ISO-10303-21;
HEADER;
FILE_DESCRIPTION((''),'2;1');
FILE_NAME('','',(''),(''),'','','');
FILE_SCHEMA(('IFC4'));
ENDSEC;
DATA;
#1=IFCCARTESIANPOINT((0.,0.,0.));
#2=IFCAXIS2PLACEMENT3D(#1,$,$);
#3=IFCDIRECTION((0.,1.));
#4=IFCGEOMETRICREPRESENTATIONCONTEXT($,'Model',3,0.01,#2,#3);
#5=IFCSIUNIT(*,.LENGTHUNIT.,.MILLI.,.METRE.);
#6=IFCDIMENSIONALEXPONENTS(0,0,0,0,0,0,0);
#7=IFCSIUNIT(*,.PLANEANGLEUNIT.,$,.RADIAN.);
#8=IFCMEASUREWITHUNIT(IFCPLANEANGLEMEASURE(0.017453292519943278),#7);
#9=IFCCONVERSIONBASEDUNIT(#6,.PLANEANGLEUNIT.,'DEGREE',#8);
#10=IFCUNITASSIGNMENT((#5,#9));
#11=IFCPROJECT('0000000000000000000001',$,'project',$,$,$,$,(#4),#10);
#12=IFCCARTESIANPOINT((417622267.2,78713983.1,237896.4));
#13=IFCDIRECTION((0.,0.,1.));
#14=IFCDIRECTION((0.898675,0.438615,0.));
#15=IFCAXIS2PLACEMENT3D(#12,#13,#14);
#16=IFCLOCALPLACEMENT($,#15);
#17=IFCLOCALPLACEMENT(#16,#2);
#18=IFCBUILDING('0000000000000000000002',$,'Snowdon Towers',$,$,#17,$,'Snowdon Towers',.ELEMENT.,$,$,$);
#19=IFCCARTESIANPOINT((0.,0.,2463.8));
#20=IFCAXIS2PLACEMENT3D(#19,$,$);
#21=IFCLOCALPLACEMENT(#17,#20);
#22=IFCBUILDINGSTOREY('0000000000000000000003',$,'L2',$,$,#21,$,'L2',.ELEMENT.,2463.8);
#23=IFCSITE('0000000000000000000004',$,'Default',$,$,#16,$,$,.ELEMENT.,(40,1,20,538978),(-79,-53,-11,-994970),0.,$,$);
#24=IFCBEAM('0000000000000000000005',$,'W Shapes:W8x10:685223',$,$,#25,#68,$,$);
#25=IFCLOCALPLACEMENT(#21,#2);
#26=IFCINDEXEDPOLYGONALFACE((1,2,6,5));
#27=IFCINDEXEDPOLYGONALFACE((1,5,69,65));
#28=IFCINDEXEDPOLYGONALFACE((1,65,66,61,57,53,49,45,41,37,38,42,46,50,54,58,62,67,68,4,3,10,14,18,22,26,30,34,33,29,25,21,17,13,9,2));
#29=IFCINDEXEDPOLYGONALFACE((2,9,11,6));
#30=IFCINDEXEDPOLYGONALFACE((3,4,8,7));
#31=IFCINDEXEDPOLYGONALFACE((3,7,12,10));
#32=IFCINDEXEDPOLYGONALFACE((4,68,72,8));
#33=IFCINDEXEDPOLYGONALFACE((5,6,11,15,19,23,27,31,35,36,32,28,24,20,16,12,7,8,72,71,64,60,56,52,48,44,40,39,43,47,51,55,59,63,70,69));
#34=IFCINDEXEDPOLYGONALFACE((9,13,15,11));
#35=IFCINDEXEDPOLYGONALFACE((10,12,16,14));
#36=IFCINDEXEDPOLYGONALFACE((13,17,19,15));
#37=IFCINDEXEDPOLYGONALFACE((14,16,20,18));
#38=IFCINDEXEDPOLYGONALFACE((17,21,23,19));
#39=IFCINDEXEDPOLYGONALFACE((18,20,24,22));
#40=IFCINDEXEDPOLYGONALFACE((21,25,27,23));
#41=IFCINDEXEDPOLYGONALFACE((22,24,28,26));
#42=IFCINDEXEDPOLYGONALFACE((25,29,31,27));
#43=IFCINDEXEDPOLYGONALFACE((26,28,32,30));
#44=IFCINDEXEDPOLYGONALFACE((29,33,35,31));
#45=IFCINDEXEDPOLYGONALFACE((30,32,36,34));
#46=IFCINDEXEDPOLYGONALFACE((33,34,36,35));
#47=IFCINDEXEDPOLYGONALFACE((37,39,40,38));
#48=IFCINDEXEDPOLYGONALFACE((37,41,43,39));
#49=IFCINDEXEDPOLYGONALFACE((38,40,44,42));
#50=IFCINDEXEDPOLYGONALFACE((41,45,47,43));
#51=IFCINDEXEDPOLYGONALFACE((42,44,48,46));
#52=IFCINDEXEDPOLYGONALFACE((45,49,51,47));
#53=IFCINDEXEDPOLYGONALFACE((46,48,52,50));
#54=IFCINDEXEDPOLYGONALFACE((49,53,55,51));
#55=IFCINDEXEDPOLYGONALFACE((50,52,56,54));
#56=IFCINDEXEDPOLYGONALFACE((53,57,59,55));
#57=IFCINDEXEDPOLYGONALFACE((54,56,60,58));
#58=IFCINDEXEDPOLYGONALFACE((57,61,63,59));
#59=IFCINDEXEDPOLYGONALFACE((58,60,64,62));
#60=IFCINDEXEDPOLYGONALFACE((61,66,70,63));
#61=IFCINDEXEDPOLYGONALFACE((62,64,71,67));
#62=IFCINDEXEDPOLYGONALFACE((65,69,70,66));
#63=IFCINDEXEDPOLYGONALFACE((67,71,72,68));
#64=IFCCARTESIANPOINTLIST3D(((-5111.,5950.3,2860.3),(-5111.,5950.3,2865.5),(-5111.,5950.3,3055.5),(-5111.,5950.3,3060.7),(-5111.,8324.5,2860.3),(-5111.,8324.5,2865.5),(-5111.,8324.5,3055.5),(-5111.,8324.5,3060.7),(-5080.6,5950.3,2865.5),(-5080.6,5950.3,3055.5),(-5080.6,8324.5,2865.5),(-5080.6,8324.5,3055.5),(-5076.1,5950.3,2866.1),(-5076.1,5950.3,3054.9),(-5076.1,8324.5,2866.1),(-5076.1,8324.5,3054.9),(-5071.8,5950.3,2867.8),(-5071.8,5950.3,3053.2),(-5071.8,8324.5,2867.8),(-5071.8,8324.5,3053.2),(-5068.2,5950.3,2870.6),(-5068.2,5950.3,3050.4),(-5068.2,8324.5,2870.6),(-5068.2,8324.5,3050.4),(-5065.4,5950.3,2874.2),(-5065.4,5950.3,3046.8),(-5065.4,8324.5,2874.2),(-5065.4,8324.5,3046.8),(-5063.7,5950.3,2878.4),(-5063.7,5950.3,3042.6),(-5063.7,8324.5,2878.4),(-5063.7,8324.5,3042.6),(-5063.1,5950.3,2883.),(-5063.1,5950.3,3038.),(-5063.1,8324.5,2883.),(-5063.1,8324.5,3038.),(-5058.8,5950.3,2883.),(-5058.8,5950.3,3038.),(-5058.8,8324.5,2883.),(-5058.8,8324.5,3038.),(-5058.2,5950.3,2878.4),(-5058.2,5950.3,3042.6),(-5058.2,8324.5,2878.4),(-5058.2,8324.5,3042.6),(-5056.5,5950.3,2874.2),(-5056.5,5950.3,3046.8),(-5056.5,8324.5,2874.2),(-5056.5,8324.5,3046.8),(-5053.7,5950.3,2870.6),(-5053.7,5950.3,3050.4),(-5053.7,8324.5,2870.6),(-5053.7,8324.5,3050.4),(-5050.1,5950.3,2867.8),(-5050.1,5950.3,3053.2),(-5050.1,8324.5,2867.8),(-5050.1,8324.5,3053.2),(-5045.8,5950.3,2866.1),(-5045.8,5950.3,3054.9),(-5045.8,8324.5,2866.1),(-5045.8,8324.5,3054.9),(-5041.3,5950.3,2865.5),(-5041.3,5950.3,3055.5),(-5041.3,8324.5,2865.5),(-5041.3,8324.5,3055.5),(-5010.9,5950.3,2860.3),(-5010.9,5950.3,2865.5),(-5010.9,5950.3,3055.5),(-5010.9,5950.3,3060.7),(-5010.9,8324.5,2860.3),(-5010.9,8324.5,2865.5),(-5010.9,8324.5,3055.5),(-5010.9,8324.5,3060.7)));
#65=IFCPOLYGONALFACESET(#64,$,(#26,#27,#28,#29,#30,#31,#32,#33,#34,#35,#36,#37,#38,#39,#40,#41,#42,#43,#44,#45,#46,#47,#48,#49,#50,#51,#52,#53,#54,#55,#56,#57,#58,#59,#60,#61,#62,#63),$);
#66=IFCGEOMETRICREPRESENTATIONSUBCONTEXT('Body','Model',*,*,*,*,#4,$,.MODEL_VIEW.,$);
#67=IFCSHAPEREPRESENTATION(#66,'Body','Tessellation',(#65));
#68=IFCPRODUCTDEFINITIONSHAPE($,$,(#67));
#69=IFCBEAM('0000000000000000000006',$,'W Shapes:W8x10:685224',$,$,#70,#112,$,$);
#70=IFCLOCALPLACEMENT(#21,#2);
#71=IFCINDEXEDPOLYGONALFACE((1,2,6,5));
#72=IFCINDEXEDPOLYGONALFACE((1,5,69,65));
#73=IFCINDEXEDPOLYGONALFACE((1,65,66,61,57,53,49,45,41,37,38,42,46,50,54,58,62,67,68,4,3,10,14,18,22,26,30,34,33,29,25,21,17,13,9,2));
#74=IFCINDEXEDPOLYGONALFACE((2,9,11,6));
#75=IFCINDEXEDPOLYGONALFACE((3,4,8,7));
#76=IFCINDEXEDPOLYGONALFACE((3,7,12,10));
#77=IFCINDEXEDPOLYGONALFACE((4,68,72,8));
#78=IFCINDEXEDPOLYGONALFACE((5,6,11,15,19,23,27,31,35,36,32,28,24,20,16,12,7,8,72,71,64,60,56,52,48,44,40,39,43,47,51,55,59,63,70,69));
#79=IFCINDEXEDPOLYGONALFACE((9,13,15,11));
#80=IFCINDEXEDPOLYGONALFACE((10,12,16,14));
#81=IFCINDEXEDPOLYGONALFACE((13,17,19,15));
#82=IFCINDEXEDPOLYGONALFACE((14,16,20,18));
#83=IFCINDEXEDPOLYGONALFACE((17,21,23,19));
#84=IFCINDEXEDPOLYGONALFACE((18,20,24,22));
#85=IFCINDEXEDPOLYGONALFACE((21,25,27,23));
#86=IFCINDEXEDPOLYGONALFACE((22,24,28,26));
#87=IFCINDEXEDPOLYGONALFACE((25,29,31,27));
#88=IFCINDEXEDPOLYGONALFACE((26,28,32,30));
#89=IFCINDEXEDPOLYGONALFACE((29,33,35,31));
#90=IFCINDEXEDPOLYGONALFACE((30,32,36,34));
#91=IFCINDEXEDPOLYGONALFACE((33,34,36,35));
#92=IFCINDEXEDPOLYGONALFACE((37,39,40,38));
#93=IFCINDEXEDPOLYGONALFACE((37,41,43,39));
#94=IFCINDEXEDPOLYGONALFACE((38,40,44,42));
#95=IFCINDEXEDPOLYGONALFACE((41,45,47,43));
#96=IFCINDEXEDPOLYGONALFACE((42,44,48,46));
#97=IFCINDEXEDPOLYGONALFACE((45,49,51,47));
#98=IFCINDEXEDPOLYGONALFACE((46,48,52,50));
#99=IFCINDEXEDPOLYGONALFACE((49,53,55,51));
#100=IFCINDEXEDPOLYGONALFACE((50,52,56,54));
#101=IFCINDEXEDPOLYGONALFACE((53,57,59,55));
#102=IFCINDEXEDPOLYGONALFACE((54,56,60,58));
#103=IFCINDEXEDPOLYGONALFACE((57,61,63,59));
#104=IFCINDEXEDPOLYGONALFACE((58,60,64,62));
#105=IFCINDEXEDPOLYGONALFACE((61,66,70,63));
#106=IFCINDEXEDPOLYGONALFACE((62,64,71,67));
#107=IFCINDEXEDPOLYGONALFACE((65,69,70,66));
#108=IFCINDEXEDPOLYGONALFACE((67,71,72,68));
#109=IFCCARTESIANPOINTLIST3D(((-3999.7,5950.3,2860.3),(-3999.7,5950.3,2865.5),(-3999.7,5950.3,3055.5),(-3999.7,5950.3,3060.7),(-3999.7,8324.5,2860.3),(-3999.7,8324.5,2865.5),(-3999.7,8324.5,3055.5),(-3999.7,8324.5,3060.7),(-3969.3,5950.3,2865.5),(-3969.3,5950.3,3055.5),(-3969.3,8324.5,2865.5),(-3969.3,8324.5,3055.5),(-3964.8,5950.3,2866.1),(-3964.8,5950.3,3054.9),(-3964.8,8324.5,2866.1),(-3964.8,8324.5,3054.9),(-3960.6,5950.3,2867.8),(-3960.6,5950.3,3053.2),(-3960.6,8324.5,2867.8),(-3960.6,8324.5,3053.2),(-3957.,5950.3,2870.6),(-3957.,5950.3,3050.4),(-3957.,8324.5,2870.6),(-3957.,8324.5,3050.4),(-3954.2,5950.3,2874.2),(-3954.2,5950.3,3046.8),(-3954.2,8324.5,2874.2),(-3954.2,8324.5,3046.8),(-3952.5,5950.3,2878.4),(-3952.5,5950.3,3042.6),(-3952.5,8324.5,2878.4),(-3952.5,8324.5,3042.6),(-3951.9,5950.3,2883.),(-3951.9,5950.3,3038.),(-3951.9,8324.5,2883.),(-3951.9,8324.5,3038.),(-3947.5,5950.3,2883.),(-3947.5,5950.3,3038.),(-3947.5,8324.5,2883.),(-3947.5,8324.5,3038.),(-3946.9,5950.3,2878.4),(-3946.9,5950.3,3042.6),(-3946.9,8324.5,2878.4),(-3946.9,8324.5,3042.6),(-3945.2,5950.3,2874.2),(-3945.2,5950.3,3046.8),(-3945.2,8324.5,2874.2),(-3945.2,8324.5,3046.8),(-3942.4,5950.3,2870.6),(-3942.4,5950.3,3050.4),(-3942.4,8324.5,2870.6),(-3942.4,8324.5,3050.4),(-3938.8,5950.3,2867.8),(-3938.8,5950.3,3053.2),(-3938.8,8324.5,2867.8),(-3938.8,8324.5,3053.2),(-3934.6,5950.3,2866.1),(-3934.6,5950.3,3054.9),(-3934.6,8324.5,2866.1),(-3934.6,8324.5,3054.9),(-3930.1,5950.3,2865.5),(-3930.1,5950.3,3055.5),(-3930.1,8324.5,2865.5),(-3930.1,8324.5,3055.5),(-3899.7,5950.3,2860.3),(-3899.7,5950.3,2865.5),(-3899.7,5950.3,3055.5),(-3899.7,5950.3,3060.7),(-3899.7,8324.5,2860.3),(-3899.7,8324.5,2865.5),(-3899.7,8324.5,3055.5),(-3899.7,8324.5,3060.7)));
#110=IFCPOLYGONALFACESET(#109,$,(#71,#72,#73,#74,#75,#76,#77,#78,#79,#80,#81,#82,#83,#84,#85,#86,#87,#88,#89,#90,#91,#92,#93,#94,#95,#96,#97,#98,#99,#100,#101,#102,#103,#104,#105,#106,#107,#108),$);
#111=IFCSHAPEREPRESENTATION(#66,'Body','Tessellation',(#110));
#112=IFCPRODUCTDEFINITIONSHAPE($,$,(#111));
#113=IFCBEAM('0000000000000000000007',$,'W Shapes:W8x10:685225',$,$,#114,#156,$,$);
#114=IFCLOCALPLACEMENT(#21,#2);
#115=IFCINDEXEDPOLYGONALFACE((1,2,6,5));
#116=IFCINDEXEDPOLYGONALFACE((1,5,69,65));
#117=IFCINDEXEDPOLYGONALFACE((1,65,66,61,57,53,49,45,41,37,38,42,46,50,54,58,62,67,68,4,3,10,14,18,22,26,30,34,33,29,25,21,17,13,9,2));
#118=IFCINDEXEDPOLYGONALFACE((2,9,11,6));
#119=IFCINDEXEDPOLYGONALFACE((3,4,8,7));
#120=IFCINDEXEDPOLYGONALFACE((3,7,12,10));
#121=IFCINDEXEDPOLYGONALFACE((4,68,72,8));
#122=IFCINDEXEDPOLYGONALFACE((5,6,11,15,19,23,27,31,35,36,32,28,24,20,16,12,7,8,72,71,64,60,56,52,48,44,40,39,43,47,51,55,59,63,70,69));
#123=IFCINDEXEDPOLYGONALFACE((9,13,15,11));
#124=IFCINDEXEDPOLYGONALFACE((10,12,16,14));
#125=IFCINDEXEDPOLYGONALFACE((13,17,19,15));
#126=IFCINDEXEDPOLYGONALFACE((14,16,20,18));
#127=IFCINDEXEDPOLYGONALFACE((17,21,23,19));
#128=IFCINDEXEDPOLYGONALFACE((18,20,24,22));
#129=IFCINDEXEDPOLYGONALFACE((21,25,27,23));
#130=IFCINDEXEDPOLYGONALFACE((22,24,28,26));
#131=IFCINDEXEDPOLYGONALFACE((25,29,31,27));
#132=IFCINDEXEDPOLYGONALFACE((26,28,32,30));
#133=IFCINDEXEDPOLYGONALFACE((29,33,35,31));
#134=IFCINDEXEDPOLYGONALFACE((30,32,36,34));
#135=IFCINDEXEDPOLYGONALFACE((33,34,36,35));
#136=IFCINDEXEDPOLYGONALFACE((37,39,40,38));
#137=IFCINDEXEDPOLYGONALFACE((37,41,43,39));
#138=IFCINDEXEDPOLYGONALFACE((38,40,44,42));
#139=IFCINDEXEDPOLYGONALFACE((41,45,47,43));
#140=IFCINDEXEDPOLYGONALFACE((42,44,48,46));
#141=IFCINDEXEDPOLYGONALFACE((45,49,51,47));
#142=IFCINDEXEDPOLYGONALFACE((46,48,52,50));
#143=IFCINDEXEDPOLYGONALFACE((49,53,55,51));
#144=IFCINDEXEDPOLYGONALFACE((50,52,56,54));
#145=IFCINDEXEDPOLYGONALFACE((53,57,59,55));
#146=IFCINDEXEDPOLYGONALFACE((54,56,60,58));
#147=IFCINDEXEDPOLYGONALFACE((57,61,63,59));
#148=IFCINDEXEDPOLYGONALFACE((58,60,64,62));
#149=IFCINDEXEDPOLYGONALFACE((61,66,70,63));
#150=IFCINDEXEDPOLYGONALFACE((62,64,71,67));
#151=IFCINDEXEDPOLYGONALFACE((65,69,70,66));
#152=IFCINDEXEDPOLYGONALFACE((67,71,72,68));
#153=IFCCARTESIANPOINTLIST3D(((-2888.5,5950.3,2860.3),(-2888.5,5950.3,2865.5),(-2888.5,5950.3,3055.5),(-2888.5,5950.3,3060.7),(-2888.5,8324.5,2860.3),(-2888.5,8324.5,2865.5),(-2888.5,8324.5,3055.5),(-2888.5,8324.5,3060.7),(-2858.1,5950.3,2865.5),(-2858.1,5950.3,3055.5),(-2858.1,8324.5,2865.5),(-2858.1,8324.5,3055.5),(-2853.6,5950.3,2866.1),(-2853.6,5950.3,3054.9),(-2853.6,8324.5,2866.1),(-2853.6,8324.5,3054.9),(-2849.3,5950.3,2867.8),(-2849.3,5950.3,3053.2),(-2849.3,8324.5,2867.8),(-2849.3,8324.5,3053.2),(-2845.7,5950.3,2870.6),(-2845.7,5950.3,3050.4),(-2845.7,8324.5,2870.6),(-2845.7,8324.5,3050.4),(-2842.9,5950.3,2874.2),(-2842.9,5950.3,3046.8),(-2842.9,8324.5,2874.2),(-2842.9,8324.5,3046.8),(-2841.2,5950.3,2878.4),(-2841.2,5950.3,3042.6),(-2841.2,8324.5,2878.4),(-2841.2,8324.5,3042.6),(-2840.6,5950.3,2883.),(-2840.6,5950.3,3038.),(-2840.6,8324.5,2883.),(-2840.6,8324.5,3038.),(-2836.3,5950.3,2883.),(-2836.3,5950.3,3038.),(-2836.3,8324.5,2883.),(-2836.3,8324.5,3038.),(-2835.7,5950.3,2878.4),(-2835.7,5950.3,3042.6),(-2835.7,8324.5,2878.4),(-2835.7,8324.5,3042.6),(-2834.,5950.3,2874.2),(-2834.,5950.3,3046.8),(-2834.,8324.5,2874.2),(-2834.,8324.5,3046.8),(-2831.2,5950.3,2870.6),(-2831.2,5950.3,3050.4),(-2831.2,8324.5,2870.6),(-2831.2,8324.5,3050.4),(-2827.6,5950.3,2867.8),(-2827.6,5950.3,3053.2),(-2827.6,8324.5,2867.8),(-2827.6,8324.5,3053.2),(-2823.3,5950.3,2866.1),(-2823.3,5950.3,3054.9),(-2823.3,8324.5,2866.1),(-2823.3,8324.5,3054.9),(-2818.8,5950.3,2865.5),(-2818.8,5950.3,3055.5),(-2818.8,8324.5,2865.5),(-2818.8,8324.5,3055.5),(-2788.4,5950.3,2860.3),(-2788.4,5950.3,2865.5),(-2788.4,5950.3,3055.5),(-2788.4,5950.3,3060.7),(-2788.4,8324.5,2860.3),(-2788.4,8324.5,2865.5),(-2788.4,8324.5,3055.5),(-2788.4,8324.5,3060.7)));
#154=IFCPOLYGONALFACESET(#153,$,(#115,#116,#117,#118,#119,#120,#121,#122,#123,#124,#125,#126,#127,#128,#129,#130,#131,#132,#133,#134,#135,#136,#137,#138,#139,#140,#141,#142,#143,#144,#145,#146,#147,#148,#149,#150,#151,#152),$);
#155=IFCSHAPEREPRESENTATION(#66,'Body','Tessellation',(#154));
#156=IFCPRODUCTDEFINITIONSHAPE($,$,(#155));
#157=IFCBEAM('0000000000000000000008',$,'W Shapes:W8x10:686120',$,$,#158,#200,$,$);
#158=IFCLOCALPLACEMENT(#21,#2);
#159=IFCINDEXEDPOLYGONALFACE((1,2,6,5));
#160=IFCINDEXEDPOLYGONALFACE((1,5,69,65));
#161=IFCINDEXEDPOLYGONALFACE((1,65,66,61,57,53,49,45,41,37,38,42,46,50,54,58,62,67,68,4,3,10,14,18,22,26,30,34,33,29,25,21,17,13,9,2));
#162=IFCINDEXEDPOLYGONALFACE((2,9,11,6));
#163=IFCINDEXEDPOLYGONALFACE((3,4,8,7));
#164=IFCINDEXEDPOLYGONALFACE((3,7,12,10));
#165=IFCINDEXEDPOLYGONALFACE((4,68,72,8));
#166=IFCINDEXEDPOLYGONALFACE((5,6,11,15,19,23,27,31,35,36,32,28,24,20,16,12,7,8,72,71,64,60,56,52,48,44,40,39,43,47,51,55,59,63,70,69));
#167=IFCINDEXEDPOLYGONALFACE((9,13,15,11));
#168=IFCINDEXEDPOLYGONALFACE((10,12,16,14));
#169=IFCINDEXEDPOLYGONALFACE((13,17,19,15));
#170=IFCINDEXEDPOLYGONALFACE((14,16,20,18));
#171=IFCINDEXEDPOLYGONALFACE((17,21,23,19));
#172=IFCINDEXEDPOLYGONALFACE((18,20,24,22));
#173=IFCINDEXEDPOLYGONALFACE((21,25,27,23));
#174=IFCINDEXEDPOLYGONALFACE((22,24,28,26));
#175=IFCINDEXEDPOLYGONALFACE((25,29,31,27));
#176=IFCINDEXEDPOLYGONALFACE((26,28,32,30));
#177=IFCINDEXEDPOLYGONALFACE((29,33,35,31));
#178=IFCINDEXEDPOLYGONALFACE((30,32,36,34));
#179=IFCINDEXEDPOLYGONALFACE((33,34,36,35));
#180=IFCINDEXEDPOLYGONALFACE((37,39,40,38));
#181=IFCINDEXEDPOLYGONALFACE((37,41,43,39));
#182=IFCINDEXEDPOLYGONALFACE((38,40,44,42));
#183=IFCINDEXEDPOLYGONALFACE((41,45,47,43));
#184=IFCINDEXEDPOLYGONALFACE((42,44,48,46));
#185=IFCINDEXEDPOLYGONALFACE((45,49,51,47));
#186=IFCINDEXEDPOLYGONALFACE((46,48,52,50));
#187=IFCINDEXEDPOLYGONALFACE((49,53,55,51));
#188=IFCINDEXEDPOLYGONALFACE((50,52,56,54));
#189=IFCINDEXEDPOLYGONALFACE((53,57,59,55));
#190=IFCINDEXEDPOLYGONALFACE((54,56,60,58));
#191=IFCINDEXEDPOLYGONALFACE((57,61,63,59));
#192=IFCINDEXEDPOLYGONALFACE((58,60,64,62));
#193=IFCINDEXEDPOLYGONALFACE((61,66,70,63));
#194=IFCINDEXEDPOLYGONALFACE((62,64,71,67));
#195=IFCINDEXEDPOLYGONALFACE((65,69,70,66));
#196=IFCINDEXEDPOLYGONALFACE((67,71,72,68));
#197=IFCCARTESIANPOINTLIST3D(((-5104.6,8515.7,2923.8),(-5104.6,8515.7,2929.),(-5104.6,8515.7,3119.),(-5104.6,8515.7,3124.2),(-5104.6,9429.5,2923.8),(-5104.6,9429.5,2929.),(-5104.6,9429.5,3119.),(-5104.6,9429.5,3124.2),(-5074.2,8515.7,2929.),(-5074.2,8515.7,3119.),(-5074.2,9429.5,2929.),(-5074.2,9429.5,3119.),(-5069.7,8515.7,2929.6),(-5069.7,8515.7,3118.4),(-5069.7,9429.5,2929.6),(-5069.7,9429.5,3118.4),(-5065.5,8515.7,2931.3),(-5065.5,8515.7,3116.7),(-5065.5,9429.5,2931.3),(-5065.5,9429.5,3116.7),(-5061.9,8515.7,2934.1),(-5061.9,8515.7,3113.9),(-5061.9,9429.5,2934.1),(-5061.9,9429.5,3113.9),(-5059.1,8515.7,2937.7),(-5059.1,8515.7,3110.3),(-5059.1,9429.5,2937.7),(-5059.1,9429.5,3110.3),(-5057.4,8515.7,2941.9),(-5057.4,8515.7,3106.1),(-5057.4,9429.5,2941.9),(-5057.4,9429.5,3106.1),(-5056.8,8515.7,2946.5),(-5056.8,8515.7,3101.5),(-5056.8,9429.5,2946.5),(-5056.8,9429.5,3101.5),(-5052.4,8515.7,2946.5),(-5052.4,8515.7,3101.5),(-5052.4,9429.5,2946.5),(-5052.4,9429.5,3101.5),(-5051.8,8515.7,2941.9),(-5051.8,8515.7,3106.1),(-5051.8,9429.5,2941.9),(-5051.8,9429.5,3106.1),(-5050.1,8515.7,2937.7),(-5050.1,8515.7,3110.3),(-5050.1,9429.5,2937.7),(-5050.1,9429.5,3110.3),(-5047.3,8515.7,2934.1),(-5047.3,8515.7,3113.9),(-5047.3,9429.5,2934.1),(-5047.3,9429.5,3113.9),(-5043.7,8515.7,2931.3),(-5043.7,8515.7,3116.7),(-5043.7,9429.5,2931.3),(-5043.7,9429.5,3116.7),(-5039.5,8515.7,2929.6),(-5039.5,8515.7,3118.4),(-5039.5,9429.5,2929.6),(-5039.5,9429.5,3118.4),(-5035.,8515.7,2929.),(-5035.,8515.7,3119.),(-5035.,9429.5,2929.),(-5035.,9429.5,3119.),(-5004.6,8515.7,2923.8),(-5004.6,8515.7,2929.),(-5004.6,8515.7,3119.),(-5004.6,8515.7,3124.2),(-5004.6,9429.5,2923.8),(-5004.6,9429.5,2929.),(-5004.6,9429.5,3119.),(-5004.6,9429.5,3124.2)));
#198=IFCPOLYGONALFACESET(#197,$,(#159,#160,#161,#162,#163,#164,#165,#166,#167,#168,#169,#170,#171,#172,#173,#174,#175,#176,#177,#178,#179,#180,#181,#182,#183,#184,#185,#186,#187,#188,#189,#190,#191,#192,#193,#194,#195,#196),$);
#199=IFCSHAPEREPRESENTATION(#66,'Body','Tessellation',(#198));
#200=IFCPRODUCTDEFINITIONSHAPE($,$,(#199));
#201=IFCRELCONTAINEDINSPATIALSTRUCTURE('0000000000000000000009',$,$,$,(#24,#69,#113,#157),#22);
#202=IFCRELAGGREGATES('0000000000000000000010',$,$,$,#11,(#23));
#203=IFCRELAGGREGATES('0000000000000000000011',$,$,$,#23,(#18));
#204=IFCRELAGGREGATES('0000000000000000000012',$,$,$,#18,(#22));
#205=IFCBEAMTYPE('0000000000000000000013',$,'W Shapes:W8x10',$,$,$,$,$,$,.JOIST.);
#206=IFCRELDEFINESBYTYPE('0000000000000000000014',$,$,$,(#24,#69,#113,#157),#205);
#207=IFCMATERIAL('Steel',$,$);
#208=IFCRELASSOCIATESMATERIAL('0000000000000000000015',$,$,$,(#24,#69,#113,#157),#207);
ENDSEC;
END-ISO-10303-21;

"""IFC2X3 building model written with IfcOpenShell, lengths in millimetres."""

from ifc_helpers import new_model, entity, si_unit, converted_unit, direction, frame, frame_2d, origin, place, context, subcontext, project, spatial, i_section, extrude, material, type_object, element, save


model = new_model("IFC2X3")

# Units and contexts
model_context = context("Model", 3, precision=0.01, world=origin(), true_north=direction((0.0, 1.0)))
body_context = subcontext(model_context, "Body", "Model", "MODEL_VIEW")
ifc_project = project(units=[si_unit("LENGTHUNIT", "METRE", prefix="MILLI"), converted_unit("PLANEANGLEUNIT", "DEGREE", entity("IfcPlaneAngleMeasure", 0.017453292519943278), si_unit("PLANEANGLEUNIT", "RADIAN"), dimensions=[0, 0, 0, 0, 0, 0, 0])], contexts=[model_context])

# Site, building, storey
site_placement = place(None, frame((417622267.2, 78713983.1, 237896.4), z_axis=(0.0, 0.0, 1.0), x_axis=(0.898675, 0.438615, 0.0)))
site = spatial("IfcSite", under=ifc_project, at=site_placement, Name="Default", CompositionType="ELEMENT", RefLatitude=(40, 1, 20, 538978), RefLongitude=(-79, -53, -11, -994970), RefElevation=0.0)
building_placement = place(site_placement, origin())
building = spatial("IfcBuilding", under=site, at=building_placement, Name="Snowdon Towers", LongName="Snowdon Towers", CompositionType="ELEMENT")
storey_placement = place(building_placement, frame((0.0, 0.0, 2463.8)))
storey = spatial("IfcBuildingStorey", under=building, at=storey_placement, Name="L2", LongName="L2", CompositionType="ELEMENT", Elevation=2463.8)

# Beams
ifc_material_1 = material(Name="Steel")
beam_type_1 = type_object("IfcBeamType", Name="W Shapes:W8x10", PredefinedType="JOIST")
beam_1_placement = place(storey_placement, frame((-5060.9, 5854.7, 3124.2), z_axis=(0.0, 0.0, 1.0), x_axis=(0.0, 1.0, 0.0)))
element("IfcBeam", 1, at=beam_1_placement, inside=storey, type_object=beam_type_1, material=ifc_material_1, Name="W Shapes:W8x10:685223", context=body_context, shape_type="SweptSolid", body=[
    extrude(i_section(OverallWidth=100.1, OverallDepth=200.4, WebThickness=4.3, FlangeThickness=5.2, FilletRadius=17.5, at=frame_2d((0.0, 0.0), x_axis=(0.0, 1.0))), frame((95.6, 0.0, -163.7), z_axis=(1.0, 0.0, 0.0), x_axis=(0.0, 0.0, -1.0)), (0.0, 0.0, 1.0), 2374.1),
])
beam_2_placement = place(storey_placement, frame((-3949.7, 5854.7, 3124.2), z_axis=(0.0, 0.0, 1.0), x_axis=(0.0, 1.0, 0.0)))
element("IfcBeam", 2, at=beam_2_placement, inside=storey, type_object=beam_type_1, material=ifc_material_1, Name="W Shapes:W8x10:685224", context=body_context, shape_type="SweptSolid", body=[
    extrude(i_section(OverallWidth=100.1, OverallDepth=200.4, WebThickness=4.3, FlangeThickness=5.2, FilletRadius=17.5, at=frame_2d((0.0, 0.0), x_axis=(0.0, 1.0))), frame((95.6, 0.0, -163.7), z_axis=(1.0, 0.0, 0.0), x_axis=(0.0, 0.0, -1.0)), (0.0, 0.0, 1.0), 2374.1),
])
beam_3_placement = place(storey_placement, frame((-2838.4, 5854.7, 3124.2), z_axis=(0.0, 0.0, 1.0), x_axis=(0.0, 1.0, 0.0)))
element("IfcBeam", 3, at=beam_3_placement, inside=storey, type_object=beam_type_1, material=ifc_material_1, Name="W Shapes:W8x10:685225", context=body_context, shape_type="SweptSolid", body=[
    extrude(i_section(OverallWidth=100.1, OverallDepth=200.4, WebThickness=4.3, FlangeThickness=5.2, FilletRadius=17.5, at=frame_2d((0.0, 0.0), x_axis=(0.0, 1.0))), frame((95.6, 0.0, -163.7), z_axis=(1.0, 0.0, 0.0), x_axis=(0.0, 0.0, -1.0)), (0.0, 0.0, 1.0), 2374.1),
])
beam_4_placement = place(storey_placement, frame((-5104.6, 8420.1, 3124.2), z_axis=(0.0, 0.0, 1.0), x_axis=(0.0, 1.0, 0.0)))
element("IfcBeam", 4, at=beam_4_placement, inside=storey, type_object=beam_type_1, material=ifc_material_1, Name="W Shapes:W8x10:686120", context=body_context, shape_type="SweptSolid", body=[
    extrude(i_section(OverallWidth=100.1, OverallDepth=200.4, WebThickness=4.3, FlangeThickness=5.2, FilletRadius=17.5, at=frame_2d((0.0, 0.0), x_axis=(0.0, 1.0))), frame((95.6, -50.0, -100.2), z_axis=(1.0, 0.0, 0.0), x_axis=(0.0, 0.0, -1.0)), (0.0, 0.0, 1.0), 913.8),
])

save(model, "model.ifc")
